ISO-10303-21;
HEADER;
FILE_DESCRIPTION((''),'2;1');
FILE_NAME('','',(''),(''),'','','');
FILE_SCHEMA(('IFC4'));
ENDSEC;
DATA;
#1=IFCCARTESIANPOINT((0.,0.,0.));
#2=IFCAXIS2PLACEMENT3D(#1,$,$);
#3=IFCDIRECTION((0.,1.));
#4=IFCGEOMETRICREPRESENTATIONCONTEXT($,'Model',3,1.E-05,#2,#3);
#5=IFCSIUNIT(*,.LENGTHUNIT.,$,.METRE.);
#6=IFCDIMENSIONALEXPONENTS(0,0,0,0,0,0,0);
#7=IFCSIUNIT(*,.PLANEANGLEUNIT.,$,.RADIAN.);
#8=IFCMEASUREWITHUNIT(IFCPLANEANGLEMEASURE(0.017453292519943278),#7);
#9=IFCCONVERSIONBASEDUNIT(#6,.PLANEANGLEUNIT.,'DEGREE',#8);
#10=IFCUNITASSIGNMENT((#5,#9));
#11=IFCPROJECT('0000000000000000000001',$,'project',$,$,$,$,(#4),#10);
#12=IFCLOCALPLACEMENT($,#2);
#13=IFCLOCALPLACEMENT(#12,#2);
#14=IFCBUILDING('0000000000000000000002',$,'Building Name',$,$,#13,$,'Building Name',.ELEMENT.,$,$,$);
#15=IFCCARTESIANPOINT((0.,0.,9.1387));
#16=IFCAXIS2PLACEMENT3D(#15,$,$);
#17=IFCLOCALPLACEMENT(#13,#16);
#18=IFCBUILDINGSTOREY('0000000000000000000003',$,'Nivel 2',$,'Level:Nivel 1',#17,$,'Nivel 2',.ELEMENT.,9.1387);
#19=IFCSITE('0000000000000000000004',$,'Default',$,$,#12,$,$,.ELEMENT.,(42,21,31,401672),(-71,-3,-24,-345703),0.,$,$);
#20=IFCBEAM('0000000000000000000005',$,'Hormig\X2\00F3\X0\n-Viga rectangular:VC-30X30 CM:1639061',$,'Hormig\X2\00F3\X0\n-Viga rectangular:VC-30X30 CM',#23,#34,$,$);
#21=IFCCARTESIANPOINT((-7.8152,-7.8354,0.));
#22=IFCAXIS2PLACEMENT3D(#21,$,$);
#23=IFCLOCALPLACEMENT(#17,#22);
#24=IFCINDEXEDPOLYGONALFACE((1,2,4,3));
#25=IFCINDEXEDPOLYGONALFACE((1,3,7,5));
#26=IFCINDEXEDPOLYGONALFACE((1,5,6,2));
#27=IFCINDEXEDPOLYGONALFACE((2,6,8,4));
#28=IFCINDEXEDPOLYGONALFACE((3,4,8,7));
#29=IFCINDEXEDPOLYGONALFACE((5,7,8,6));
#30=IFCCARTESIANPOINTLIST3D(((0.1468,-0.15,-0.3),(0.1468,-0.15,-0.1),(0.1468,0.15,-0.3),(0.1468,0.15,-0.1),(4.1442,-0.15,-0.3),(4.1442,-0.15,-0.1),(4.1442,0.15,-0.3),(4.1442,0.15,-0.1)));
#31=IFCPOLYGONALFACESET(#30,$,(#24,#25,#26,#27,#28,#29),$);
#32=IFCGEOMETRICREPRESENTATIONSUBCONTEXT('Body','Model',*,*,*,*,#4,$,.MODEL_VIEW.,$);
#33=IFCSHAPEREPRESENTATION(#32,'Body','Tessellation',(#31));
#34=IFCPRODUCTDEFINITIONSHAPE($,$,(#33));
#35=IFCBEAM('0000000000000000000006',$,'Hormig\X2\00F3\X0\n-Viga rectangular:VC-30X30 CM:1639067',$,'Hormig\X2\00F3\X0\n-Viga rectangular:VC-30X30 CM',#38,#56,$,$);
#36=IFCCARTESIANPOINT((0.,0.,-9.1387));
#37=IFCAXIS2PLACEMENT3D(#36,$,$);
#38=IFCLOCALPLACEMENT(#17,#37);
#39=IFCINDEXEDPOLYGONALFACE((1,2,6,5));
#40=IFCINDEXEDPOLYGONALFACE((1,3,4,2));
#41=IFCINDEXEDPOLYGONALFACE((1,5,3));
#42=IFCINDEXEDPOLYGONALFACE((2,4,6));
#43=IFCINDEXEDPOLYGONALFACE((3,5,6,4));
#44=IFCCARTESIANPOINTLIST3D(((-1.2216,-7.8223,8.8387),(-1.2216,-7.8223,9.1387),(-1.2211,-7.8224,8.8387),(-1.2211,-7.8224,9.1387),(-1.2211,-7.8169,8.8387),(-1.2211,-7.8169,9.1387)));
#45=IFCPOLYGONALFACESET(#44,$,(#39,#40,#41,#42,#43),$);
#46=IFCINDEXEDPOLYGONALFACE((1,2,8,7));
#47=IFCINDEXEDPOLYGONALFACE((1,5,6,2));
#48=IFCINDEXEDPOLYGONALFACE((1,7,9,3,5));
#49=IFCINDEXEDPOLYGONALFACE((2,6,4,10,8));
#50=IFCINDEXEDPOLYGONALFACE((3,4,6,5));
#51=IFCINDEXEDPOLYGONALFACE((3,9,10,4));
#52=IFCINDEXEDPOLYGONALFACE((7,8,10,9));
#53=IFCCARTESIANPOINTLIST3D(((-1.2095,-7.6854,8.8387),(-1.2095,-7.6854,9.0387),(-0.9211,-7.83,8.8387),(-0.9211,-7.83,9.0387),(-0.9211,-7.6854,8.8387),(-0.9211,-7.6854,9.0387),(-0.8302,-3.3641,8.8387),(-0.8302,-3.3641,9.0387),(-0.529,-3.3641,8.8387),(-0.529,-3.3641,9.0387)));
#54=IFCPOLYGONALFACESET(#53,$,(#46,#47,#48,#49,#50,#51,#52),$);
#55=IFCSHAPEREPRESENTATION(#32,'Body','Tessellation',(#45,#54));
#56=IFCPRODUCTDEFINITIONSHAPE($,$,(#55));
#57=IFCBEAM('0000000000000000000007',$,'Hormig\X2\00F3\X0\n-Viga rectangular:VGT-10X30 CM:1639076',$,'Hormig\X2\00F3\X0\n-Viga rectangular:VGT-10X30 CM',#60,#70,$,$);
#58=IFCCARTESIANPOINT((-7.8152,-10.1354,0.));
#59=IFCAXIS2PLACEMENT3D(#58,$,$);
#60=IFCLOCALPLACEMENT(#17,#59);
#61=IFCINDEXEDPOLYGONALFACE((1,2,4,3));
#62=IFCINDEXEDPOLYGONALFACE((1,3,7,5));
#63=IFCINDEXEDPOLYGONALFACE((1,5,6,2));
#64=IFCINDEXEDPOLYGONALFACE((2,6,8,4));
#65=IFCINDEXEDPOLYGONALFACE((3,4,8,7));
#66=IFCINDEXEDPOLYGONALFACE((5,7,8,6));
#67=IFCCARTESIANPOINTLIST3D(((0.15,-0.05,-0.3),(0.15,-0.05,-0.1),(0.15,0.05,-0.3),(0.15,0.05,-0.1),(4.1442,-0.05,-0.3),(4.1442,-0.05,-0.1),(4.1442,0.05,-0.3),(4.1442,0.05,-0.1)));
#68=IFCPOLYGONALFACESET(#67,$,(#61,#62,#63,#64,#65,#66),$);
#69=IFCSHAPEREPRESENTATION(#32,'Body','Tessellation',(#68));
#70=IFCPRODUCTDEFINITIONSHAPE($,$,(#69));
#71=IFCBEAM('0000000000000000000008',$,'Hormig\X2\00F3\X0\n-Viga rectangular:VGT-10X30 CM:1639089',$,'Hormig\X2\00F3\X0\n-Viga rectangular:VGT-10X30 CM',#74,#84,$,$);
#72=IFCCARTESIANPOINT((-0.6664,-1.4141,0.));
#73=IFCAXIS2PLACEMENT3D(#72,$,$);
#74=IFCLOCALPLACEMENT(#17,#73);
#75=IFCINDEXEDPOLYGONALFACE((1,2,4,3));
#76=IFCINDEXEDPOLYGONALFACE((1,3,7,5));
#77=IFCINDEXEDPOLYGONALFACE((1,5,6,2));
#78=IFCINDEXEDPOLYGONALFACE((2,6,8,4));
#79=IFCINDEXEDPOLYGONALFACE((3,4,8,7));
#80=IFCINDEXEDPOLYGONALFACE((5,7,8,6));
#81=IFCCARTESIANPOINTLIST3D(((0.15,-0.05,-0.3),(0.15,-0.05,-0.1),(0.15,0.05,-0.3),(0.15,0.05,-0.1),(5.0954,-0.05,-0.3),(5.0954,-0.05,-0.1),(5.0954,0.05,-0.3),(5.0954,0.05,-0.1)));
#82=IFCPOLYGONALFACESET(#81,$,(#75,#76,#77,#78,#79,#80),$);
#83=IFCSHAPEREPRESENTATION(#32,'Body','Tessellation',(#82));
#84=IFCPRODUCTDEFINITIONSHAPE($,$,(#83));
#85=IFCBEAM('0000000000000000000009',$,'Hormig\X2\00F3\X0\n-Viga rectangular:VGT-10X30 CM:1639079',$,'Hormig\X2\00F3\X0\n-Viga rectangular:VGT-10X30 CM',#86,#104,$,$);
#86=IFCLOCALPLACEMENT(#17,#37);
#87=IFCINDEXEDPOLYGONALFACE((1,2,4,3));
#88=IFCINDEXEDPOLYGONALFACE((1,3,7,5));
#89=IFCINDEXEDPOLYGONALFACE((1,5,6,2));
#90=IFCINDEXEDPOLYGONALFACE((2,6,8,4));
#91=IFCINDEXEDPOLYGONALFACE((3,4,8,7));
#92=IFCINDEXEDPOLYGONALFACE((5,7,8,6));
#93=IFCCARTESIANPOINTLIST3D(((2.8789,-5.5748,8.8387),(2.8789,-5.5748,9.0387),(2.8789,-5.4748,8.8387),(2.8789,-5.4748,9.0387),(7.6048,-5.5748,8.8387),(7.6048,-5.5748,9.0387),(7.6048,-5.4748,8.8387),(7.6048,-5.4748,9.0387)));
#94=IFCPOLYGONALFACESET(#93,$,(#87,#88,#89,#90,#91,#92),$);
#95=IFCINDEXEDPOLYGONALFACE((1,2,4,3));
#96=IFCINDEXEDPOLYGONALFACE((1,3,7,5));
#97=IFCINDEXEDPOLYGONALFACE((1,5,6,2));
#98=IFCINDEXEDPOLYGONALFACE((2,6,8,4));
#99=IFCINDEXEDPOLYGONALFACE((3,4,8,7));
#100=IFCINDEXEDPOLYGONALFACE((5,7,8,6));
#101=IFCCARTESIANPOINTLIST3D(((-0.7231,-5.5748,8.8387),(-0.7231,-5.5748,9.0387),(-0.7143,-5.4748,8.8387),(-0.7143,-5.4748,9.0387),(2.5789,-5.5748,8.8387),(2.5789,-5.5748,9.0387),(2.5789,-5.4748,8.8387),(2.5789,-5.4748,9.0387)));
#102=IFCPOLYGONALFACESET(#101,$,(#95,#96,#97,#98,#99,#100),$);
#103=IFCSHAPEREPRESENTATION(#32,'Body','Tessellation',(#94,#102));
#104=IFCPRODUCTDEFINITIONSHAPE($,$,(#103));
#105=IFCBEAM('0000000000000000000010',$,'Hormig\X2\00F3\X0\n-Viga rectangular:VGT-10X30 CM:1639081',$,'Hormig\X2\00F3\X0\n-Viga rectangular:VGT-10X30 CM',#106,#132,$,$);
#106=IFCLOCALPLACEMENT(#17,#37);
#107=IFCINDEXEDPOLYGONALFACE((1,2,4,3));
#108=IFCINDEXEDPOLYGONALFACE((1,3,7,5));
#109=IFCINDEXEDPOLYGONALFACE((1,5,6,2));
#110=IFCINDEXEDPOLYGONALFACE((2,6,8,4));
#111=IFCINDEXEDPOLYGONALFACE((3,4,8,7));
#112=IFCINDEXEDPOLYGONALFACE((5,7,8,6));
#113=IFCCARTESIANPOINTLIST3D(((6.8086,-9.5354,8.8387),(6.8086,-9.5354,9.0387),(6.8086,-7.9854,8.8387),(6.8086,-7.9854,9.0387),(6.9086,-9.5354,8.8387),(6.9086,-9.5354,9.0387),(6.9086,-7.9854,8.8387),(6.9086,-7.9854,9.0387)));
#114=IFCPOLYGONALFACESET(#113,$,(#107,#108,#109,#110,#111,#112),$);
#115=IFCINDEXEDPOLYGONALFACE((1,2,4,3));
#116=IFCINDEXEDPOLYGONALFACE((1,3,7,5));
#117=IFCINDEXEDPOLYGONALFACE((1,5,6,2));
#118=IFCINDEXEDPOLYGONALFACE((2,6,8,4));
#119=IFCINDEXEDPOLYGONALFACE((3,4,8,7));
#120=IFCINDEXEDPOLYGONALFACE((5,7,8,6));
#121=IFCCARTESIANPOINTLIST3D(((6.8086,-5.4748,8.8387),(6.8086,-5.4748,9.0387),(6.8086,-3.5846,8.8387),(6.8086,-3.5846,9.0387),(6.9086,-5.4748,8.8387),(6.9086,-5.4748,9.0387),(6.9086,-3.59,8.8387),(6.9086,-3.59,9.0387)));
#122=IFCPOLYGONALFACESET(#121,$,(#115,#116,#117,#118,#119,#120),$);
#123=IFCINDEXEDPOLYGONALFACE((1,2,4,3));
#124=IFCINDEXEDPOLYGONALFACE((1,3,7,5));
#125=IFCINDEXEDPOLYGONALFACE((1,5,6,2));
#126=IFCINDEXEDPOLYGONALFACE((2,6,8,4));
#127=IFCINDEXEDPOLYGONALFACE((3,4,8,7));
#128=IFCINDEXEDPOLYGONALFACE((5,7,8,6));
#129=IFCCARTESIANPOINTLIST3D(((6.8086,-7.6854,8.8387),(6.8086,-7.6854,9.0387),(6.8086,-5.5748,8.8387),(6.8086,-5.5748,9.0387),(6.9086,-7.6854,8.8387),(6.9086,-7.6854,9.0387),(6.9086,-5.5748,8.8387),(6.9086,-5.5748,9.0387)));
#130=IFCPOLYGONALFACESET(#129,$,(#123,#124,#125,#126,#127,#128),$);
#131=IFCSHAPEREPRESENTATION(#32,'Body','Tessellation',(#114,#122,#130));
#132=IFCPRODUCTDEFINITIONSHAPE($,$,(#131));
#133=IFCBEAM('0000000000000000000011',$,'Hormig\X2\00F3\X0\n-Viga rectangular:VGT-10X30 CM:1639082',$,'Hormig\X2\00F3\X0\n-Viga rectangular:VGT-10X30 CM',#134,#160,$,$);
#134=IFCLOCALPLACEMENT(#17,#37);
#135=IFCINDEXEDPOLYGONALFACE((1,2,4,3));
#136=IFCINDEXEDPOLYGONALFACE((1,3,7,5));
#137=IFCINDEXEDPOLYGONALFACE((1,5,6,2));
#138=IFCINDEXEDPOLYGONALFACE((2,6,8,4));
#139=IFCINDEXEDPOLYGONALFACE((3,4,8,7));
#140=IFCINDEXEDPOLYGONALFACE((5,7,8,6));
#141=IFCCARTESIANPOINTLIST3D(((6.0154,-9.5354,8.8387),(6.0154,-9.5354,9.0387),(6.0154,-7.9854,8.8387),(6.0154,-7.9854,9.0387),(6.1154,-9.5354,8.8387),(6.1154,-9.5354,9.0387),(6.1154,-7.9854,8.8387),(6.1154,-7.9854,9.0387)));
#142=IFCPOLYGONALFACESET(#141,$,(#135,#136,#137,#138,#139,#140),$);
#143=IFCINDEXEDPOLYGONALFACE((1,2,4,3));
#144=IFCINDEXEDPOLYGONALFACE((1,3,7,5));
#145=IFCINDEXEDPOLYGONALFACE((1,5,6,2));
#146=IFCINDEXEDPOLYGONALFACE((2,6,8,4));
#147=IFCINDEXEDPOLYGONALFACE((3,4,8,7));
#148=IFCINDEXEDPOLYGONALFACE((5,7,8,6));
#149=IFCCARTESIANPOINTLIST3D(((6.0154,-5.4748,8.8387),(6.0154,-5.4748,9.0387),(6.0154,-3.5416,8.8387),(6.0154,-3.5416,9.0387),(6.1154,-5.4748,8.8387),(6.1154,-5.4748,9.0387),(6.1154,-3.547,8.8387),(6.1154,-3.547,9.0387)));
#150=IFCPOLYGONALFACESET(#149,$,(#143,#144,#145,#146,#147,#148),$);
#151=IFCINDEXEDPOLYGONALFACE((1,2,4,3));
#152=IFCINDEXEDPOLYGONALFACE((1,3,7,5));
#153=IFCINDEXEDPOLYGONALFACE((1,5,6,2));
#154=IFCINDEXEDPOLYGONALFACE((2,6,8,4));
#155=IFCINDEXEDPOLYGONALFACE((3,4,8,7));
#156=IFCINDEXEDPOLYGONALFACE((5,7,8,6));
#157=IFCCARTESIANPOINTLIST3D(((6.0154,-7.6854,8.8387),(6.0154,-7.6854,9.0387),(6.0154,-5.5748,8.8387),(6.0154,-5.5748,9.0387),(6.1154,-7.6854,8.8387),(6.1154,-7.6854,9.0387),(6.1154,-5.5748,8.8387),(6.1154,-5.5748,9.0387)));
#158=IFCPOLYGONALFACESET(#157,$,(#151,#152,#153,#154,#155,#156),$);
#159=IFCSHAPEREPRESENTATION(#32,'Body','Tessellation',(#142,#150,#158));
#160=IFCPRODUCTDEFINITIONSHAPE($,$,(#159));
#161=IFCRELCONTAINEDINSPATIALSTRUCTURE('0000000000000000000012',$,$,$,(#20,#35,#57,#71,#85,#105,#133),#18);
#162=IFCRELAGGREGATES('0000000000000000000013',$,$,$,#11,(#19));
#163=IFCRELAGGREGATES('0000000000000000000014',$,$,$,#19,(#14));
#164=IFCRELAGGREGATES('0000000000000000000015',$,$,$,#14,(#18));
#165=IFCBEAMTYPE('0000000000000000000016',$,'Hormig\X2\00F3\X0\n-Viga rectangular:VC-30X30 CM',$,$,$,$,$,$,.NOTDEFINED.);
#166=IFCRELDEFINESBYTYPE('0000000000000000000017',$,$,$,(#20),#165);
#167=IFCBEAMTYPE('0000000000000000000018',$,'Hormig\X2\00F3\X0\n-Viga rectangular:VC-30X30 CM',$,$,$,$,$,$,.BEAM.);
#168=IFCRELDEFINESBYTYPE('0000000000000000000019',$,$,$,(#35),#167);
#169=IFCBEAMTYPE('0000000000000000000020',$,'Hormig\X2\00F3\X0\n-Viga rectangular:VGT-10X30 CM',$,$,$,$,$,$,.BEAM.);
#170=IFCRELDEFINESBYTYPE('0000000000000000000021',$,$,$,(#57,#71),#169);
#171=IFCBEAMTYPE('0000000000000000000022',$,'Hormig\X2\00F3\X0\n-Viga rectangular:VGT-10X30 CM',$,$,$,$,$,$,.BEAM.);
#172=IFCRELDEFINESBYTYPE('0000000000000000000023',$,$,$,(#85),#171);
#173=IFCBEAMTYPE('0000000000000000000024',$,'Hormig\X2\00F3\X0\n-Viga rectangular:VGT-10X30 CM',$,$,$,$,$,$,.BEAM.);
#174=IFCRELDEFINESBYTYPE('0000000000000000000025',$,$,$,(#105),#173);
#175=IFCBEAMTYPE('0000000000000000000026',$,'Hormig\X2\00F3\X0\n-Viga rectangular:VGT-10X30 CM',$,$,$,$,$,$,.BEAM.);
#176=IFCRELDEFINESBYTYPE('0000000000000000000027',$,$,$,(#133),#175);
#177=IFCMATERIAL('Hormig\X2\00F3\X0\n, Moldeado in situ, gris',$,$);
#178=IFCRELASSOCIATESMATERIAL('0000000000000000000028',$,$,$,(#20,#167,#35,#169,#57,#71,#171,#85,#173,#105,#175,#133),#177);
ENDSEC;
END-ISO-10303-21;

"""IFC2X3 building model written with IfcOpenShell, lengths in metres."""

from ifc_helpers import new_model, entity, si_unit, converted_unit, direction, frame, frame_2d, origin, origin_2d_with_axis, place, context, subcontext, project, spatial, polyline, rectangle, extrude, clip, halfspace, bounded_halfspace, source, transform, mapped, material, type_object, type_shapes, element, save


model = new_model("IFC2X3")

# Units and contexts
model_context = context("Model", 3, precision=1e-05, world=origin(), true_north=direction((0.0, 1.0)))
body_context = subcontext(model_context, "Body", "Model", "MODEL_VIEW")
ifc_project = project(units=[si_unit("LENGTHUNIT", "METRE"), converted_unit("PLANEANGLEUNIT", "DEGREE", entity("IfcPlaneAngleMeasure", 0.017453292519943278), si_unit("PLANEANGLEUNIT", "RADIAN"), dimensions=[0, 0, 0, 0, 0, 0, 0])], contexts=[model_context])

# Site, building, storey
site_placement = place(None, origin())
site = spatial("IfcSite", under=ifc_project, at=site_placement, Name="Default", CompositionType="ELEMENT", RefLatitude=(42, 21, 31, 401672), RefLongitude=(-71, -3, -24, -345703), RefElevation=0.0)
building_placement = place(site_placement, origin())
building = spatial("IfcBuilding", under=site, at=building_placement, Name="Building Name", LongName="Building Name", CompositionType="ELEMENT")
storey_placement = place(building_placement, frame((0.0, 0.0, 9.1387)))
storey = spatial("IfcBuildingStorey", under=building, at=storey_placement, Name="Nivel 2", ObjectType="Level:Nivel 1", LongName="Nivel 2", CompositionType="ELEMENT", Elevation=9.1387)

# Beams
ifc_material = material(Name="Hormigón, Moldeado in situ, gris")
beam_type_1 = type_object("IfcBeamType", Name="Hormigón-Viga rectangular:VC-30X30 CM", PredefinedType="NOTDEFINED")
beam_1_placement = place(storey_placement, frame((-7.8152, -7.8354, 0.0)))
element("IfcBeam", 1, at=beam_1_placement, inside=storey, type_object=beam_type_1, material=ifc_material, Name="Hormigón-Viga rectangular:VC-30X30 CM:1639061", ObjectType="Hormigón-Viga rectangular:VC-30X30 CM", context=body_context, shape_type="SweptSolid", body=[
    extrude(rectangle(XDim=0.2, YDim=0.3, at=frame_2d((0.0, 0.0), x_axis=(1.0, 0.0))), frame((0.1468, 0.0, -0.2), z_axis=(1.0, 0.0, 0.0), x_axis=(0.0, 0.0, -1.0)), (0.0, 0.0, 1.0), 3.9973),
])
beam_type_2 = type_object("IfcBeamType", Name="Hormigón-Viga rectangular:VC-30X30 CM", PredefinedType="BEAM", material=ifc_material)
shared_shape_1 = source(origin(), body_context, "Body", "SweptSolid", [
    clip(extrude(rectangle(XDim=0.3, YDim=0.0005, at=origin_2d_with_axis()), frame((-1.2208, -7.8169, 8.9887), z_axis=(-0.087456, -0.996168, 0.0), x_axis=(0.0, 0.0, -1.0)), (0.0, 0.0, 1.0), 0.0055), halfspace(frame((-1.2211, -7.6854, 9.1387), z_axis=(1.0, 0.0, 0.0), x_axis=(0.0, 0.0, -1.0)), False)),
    clip(clip(clip(extrude(rectangle(XDim=0.2, YDim=0.3, at=frame_2d((0.0, 0.0), x_axis=(1.0, 0.0))), frame((-0.6784, -3.351, 8.9387), z_axis=(-0.087456, -0.996168, 0.0), x_axis=(0.0, 0.0, -1.0)), (0.0, 0.0, 1.0), 4.4831), halfspace(frame((2.5788, -3.3641, 9.1387), z_axis=(0.0, 1.0, 0.0), x_axis=(-1.0, 0.0, 0.0)), False)), bounded_halfspace(frame((-0.9211, -7.9854, 9.1387), z_axis=(-1.0, 0.0, 0.0), x_axis=(0.0, 0.0, -1.0)), False, frame((-0.6784, -3.351, 8.9387), z_axis=(-0.087456, -0.996168, 0.0), x_axis=(0.0, 0.0, -1.0)), polyline([(0.1, 0.1374), (0.1, 0.15), (-0.1, 0.15), (-0.1, 0.1374), (0.1, 0.1374)]))), bounded_halfspace(frame((-0.9211, -7.6854, 9.1387), z_axis=(0.0, -1.0, 0.0), x_axis=(0.0, 0.0, -1.0)), False, frame((-0.6784, -3.351, 8.9387), z_axis=(-0.087456, -0.996168, 0.0), x_axis=(0.0, 0.0, -1.0)), polyline([(0.1, -0.15), (0.1, 0.1374), (-0.1, 0.1374), (-0.1, -0.15), (0.1, -0.15)]))),
])
type_shapes(beam_type_2, [shared_shape_1])
beam_2_placement = place(storey_placement, frame((0.0, 0.0, -9.1387)))
element("IfcBeam", 2, at=beam_2_placement, inside=storey, type_object=beam_type_2, material=ifc_material, Name="Hormigón-Viga rectangular:VC-30X30 CM:1639067", ObjectType="Hormigón-Viga rectangular:VC-30X30 CM", context=body_context, shape_type="MappedRepresentation", body=[
    mapped(shared_shape_1, transform((0.0, 0.0, 0.0), scale=1.0)),
])
beam_type_3 = type_object("IfcBeamType", Name="Hormigón-Viga rectangular:VGT-10X30 CM", PredefinedType="BEAM", material=ifc_material)
beam_3_placement = place(storey_placement, frame((-7.8152, -10.1354, 0.0)))
element("IfcBeam", 3, at=beam_3_placement, inside=storey, type_object=beam_type_3, material=ifc_material, Name="Hormigón-Viga rectangular:VGT-10X30 CM:1639076", ObjectType="Hormigón-Viga rectangular:VGT-10X30 CM", context=body_context, shape_type="SweptSolid", body=[
    extrude(rectangle(XDim=0.2, YDim=0.1, at=frame_2d((0.0, 0.0), x_axis=(1.0, 0.0))), frame((0.15, 0.0, -0.2), z_axis=(1.0, 0.0, 0.0), x_axis=(0.0, 0.0, -1.0)), (0.0, 0.0, 1.0), 3.9942),
])
beam_4_placement = place(storey_placement, frame((-0.6664, -1.4141, 0.0)))
element("IfcBeam", 4, at=beam_4_placement, inside=storey, type_object=beam_type_3, material=ifc_material, Name="Hormigón-Viga rectangular:VGT-10X30 CM:1639089", ObjectType="Hormigón-Viga rectangular:VGT-10X30 CM", context=body_context, shape_type="SweptSolid", body=[
    extrude(rectangle(XDim=0.2, YDim=0.1, at=frame_2d((0.0, 0.0), x_axis=(1.0, 0.0))), frame((0.15, 0.0, -0.2), z_axis=(1.0, 0.0, 0.0), x_axis=(0.0, 0.0, -1.0)), (0.0, 0.0, 1.0), 4.9454),
])
beam_type_4 = type_object("IfcBeamType", Name="Hormigón-Viga rectangular:VGT-10X30 CM", PredefinedType="BEAM", material=ifc_material)
shared_shape_2 = source(origin(), body_context, "Body", "SweptSolid", [
    extrude(rectangle(XDim=0.2, YDim=0.1, at=frame_2d((0.0, 0.0), x_axis=(1.0, 0.0))), frame((2.8789, -5.5248, 8.9387), z_axis=(1.0, 0.0, 0.0), x_axis=(0.0, 0.0, -1.0)), (0.0, 0.0, 1.0), 4.7258),
    clip(extrude(rectangle(XDim=0.2, YDim=0.1, at=frame_2d((0.0, 0.0), x_axis=(1.0, 0.0))), frame((-0.7231, -5.5248, 8.9387), z_axis=(1.0, 0.0, 0.0), x_axis=(0.0, 0.0, -1.0)), (0.0, 0.0, 1.0), 3.302), halfspace(frame((-0.9084, -7.6861, 8.8387), z_axis=(-0.996168, 0.087456, 0.0), x_axis=(0.087456, 0.996168, 0.0)), False)),
])
type_shapes(beam_type_4, [shared_shape_2])
beam_5_placement = place(storey_placement, frame((0.0, 0.0, -9.1387)))
element("IfcBeam", 5, at=beam_5_placement, inside=storey, type_object=beam_type_4, material=ifc_material, Name="Hormigón-Viga rectangular:VGT-10X30 CM:1639079", ObjectType="Hormigón-Viga rectangular:VGT-10X30 CM", context=body_context, shape_type="MappedRepresentation", body=[
    mapped(shared_shape_2, transform((0.0, 0.0, 0.0), scale=1.0)),
])
beam_type_5 = type_object("IfcBeamType", Name="Hormigón-Viga rectangular:VGT-10X30 CM", PredefinedType="BEAM", material=ifc_material)
shared_shape_3 = source(origin(), body_context, "Body", "SweptSolid", [
    extrude(rectangle(XDim=0.2, YDim=0.1, at=frame_2d((0.0, 0.0), x_axis=(0.0, 1.0))), frame((6.8586, -7.9854, 8.9387), z_axis=(0.0, -1.0, 0.0), x_axis=(-1.0, 0.0, 0.0)), (0.0, 0.0, 1.0), 1.55),
    clip(extrude(rectangle(XDim=0.2, YDim=0.1, at=frame_2d((0.0, 0.0), x_axis=(0.0, 1.0))), frame((6.8586, -3.5846, 8.9387), z_axis=(0.0, -1.0, 0.0), x_axis=(-1.0, 0.0, 0.0)), (0.0, 0.0, 1.0), 1.8902), halfspace(frame((7.5858, -3.6267, 9.1387), z_axis=(0.054083, 0.998536, 0.0), x_axis=(-0.998536, 0.054083, 0.0)), False)),
    extrude(rectangle(XDim=0.2, YDim=0.1, at=frame_2d((0.0, 0.0), x_axis=(0.0, 1.0))), frame((6.8586, -5.5748, 8.9387), z_axis=(0.0, -1.0, 0.0), x_axis=(-1.0, 0.0, 0.0)), (0.0, 0.0, 1.0), 2.1107),
])
type_shapes(beam_type_5, [shared_shape_3])
beam_6_placement = place(storey_placement, frame((0.0, 0.0, -9.1387)))
element("IfcBeam", 6, at=beam_6_placement, inside=storey, type_object=beam_type_5, material=ifc_material, Name="Hormigón-Viga rectangular:VGT-10X30 CM:1639081", ObjectType="Hormigón-Viga rectangular:VGT-10X30 CM", context=body_context, shape_type="MappedRepresentation", body=[
    mapped(shared_shape_3, transform((0.0, 0.0, 0.0), scale=1.0)),
])
beam_type_6 = type_object("IfcBeamType", Name="Hormigón-Viga rectangular:VGT-10X30 CM", PredefinedType="BEAM", material=ifc_material)
shared_shape_4 = source(origin(), body_context, "Body", "SweptSolid", [
    extrude(rectangle(XDim=0.2, YDim=0.1, at=frame_2d((0.0, 0.0), x_axis=(0.0, 1.0))), frame((6.0654, -7.9854, 8.9387), z_axis=(0.0, -1.0, 0.0), x_axis=(-1.0, 0.0, 0.0)), (0.0, 0.0, 1.0), 1.55),
    clip(extrude(rectangle(XDim=0.2, YDim=0.1, at=frame_2d((0.0, 0.0), x_axis=(0.0, 1.0))), frame((6.0654, -3.5416, 8.9387), z_axis=(0.0, -1.0, 0.0), x_axis=(-1.0, 0.0, 0.0)), (0.0, 0.0, 1.0), 1.9331), halfspace(frame((7.5858, -3.6267, 9.1387), z_axis=(0.054083, 0.998536, 0.0), x_axis=(-0.998536, 0.054083, 0.0)), False)),
    extrude(rectangle(XDim=0.2, YDim=0.1, at=frame_2d((0.0, 0.0), x_axis=(0.0, 1.0))), frame((6.0654, -5.5748, 8.9387), z_axis=(0.0, -1.0, 0.0), x_axis=(-1.0, 0.0, 0.0)), (0.0, 0.0, 1.0), 2.1107),
])
type_shapes(beam_type_6, [shared_shape_4])
beam_7_placement = place(storey_placement, frame((0.0, 0.0, -9.1387)))
element("IfcBeam", 7, at=beam_7_placement, inside=storey, type_object=beam_type_6, material=ifc_material, Name="Hormigón-Viga rectangular:VGT-10X30 CM:1639082", ObjectType="Hormigón-Viga rectangular:VGT-10X30 CM", context=body_context, shape_type="MappedRepresentation", body=[
    mapped(shared_shape_4, transform((0.0, 0.0, 0.0), scale=1.0)),
])

save(model, "model.ifc")
